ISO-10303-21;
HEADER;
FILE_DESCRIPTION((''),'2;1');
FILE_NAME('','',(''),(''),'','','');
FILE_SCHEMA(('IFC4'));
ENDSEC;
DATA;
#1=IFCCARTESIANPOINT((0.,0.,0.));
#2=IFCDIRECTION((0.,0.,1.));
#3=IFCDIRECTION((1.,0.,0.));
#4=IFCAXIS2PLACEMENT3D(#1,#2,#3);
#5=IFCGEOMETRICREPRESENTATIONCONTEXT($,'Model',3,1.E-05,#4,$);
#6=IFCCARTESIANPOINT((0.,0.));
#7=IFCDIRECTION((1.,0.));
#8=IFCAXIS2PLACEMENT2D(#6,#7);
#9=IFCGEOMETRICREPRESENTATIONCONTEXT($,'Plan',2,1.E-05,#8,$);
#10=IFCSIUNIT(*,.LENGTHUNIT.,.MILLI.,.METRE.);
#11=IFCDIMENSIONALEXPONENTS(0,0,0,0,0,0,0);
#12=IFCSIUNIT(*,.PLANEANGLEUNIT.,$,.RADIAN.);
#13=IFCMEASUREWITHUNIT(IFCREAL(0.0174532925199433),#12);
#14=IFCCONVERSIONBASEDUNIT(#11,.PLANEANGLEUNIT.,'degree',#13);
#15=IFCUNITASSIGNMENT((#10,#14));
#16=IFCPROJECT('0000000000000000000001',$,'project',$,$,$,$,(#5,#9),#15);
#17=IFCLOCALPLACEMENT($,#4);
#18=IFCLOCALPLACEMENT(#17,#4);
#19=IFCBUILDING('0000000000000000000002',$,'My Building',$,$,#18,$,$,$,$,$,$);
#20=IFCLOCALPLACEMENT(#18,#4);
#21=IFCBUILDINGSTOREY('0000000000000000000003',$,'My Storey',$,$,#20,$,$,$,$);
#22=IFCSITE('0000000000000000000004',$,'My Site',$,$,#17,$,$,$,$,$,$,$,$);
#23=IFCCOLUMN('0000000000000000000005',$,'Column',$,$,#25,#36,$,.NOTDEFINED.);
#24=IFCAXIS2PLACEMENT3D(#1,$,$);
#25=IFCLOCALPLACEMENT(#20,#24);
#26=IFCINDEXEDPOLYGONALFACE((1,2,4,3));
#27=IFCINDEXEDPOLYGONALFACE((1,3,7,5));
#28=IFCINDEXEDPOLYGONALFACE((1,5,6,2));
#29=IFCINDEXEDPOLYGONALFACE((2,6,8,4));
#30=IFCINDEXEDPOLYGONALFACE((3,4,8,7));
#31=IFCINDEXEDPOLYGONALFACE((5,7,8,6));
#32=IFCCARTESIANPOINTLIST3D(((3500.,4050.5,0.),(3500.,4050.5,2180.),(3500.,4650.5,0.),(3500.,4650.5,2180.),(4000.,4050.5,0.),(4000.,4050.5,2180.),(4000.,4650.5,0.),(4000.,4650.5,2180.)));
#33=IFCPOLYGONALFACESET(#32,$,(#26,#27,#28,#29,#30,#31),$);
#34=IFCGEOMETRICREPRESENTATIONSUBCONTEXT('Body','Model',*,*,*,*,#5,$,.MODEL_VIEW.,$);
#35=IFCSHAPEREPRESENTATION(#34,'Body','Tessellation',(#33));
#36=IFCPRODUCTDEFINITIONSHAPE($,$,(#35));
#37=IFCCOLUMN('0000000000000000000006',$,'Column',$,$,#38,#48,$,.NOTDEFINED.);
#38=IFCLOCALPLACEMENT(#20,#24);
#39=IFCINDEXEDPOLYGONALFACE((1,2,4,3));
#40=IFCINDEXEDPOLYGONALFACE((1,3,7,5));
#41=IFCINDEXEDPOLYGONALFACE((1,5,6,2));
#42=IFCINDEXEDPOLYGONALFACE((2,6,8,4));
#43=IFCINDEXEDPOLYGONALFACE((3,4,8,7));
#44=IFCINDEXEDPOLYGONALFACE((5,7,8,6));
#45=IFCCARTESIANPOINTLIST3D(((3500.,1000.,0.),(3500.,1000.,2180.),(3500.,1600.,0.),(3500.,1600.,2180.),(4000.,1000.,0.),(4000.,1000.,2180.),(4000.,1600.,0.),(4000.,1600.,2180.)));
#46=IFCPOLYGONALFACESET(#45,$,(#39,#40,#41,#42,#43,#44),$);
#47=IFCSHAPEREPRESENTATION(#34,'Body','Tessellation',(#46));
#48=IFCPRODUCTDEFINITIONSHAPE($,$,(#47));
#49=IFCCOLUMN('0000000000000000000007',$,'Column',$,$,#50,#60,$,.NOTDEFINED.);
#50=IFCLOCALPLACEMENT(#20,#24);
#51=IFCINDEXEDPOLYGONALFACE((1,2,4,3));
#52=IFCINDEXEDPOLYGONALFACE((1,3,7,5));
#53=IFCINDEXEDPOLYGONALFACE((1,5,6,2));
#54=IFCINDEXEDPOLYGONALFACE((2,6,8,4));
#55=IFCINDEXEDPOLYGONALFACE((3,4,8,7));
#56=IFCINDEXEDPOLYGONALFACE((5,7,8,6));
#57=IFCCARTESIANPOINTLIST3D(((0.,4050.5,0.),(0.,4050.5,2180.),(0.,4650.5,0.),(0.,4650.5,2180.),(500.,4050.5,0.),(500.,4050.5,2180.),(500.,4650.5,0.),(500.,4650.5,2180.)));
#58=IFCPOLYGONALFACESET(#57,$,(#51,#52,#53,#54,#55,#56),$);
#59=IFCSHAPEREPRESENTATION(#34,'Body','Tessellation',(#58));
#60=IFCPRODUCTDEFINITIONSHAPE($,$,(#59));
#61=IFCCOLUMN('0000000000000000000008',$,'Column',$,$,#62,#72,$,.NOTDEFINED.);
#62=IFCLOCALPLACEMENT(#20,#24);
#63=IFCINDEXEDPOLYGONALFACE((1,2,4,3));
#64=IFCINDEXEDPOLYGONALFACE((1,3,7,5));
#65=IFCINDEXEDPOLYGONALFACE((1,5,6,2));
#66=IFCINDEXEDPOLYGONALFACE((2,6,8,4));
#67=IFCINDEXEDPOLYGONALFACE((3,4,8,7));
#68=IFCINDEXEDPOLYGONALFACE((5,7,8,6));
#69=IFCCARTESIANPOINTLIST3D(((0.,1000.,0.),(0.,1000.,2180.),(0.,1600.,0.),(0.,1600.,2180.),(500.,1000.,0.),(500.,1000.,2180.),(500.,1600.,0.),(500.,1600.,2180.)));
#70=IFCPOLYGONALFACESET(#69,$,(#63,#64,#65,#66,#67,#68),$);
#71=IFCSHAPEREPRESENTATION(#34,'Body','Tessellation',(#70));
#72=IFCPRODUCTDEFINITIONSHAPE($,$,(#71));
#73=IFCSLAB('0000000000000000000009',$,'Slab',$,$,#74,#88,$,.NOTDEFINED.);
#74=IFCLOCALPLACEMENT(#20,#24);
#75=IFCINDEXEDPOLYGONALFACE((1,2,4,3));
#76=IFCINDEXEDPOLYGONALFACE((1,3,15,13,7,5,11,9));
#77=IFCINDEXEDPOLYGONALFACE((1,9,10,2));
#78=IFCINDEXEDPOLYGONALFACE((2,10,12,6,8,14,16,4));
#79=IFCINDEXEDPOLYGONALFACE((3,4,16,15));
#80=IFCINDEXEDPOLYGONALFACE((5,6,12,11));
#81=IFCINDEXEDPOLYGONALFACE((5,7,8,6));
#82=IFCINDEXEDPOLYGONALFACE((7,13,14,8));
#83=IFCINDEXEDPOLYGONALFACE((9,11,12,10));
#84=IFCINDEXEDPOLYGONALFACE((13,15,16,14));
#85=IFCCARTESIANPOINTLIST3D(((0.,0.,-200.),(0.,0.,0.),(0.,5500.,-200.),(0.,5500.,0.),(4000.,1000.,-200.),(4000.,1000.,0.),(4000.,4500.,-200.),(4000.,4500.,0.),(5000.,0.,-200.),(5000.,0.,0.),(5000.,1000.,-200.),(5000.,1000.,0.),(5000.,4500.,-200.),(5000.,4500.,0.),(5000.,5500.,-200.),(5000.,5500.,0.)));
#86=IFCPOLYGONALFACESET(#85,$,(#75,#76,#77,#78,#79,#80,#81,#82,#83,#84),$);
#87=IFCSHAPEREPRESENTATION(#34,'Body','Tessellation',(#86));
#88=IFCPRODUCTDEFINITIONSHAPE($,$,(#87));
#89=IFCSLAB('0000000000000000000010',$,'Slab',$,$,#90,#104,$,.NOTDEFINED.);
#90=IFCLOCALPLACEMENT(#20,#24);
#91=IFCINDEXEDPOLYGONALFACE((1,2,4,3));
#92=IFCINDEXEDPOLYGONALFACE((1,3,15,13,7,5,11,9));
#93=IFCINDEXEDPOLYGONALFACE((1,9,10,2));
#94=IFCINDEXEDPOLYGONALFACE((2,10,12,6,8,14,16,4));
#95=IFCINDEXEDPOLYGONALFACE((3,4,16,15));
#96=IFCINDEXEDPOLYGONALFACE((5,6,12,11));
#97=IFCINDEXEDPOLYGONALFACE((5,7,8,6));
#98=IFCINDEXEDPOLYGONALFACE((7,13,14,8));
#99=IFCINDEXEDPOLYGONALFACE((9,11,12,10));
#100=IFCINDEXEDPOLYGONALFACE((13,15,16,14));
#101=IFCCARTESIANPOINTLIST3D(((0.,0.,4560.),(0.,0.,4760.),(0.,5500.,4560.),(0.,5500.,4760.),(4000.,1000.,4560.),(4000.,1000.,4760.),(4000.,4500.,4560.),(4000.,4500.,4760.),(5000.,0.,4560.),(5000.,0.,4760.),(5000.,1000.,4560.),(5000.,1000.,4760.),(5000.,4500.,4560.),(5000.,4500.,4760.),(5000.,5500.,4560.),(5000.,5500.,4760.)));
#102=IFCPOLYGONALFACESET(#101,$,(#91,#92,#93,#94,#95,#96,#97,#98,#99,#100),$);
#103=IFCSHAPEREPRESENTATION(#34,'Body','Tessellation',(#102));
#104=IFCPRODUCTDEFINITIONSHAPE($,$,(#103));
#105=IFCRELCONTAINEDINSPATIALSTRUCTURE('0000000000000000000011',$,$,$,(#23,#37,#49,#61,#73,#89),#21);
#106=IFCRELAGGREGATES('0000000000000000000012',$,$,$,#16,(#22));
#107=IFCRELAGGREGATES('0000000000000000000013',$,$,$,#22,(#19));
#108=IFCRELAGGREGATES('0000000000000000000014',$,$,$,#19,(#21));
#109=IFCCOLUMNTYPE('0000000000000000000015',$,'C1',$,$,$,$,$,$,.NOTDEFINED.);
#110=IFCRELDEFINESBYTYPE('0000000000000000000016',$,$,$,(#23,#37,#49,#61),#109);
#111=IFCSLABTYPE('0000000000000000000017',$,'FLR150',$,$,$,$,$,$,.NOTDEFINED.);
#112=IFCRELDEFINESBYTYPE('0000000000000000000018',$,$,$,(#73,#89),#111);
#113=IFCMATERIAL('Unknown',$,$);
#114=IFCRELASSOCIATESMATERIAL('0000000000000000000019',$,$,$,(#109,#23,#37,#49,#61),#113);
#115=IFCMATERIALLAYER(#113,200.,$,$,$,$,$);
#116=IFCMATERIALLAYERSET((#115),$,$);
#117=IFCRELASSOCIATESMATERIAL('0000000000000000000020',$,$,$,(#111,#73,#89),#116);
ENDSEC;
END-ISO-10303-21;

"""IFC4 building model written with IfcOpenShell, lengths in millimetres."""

from ifc_helpers import new_model, entity, si_unit, converted_unit, frame, origin_with_axes, origin_2d_with_axis, place, context, subcontext, project, spatial, line, indexed_curve, rectangle, outline, extrude, material, layer, layer_set, layer_usage, material_profile, profile_set, profile_usage, type_object, element, save


model = new_model("IFC4")

# Units and contexts
model_context = context("Model", 3, precision=1e-05, world=origin_with_axes())
plan_context = context("Plan", 2, precision=1e-05, world=origin_2d_with_axis())
body_context = subcontext(model_context, "Body", "Model", "MODEL_VIEW")
ifc_project = project(units=[si_unit("LENGTHUNIT", "METRE", prefix="MILLI"), converted_unit("PLANEANGLEUNIT", "degree", entity("IfcReal", 0.0174532925199433), si_unit("PLANEANGLEUNIT", "RADIAN"), dimensions=[0, 0, 0, 0, 0, 0, 0])], contexts=[model_context, plan_context])

# Site, building, storey
site_placement = place(None, origin_with_axes())
site = spatial("IfcSite", under=ifc_project, at=site_placement, Name="My Site")
building_placement = place(site_placement, origin_with_axes())
building = spatial("IfcBuilding", under=site, at=building_placement, Name="My Building")
storey_placement = place(building_placement, origin_with_axes())
storey = spatial("IfcBuildingStorey", under=building, at=storey_placement, Name="My Storey")

# Columns
ifc_material = material(Name="Unknown")
ifc_material_profile = material_profile(ifc_material, rectangle(XDim=500.0, YDim=600.0))
ifc_profile_set = profile_set([ifc_material_profile])
ifc_profile_usage_1 = profile_usage(ifc_profile_set, cardinal=5)
column_type = type_object("IfcColumnType", Name="C1", PredefinedType="NOTDEFINED", material=ifc_profile_set)
column_1_placement = place(storey_placement, frame((3750.0, 4350.5, 0.0), z_axis=(0.0, 0.0, 1.0), x_axis=(1.0, 0.0, 0.0)))
element("IfcColumn", 1, at=column_1_placement, inside=storey, type_object=column_type, material=ifc_profile_usage_1, Name="Column", PredefinedType="NOTDEFINED", context=body_context, shape_type="SweptSolid", body=[
    extrude(rectangle(XDim=500.0, YDim=600.0), origin_with_axes(), (0.0, 0.0, 1.0), 2180.0),
])
ifc_profile_usage_2 = profile_usage(ifc_profile_set, cardinal=5)
column_2_placement = place(storey_placement, frame((3750.0, 1300.0, 0.0), z_axis=(0.0, 0.0, 1.0), x_axis=(1.0, 0.0, 0.0)))
element("IfcColumn", 2, at=column_2_placement, inside=storey, type_object=column_type, material=ifc_profile_usage_2, Name="Column", PredefinedType="NOTDEFINED", context=body_context, shape_type="SweptSolid", body=[
    extrude(rectangle(XDim=500.0, YDim=600.0), origin_with_axes(), (0.0, 0.0, 1.0), 2180.0),
])
ifc_profile_usage_3 = profile_usage(ifc_profile_set, cardinal=5)
column_3_placement = place(storey_placement, frame((250.0, 4350.5, 0.0), z_axis=(0.0, 0.0, 1.0), x_axis=(1.0, 0.0, 0.0)))
element("IfcColumn", 3, at=column_3_placement, inside=storey, type_object=column_type, material=ifc_profile_usage_3, Name="Column", PredefinedType="NOTDEFINED", context=body_context, shape_type="SweptSolid", body=[
    extrude(rectangle(XDim=500.0, YDim=600.0), origin_with_axes(), (0.0, 0.0, 1.0), 2180.0),
])
ifc_profile_usage_4 = profile_usage(ifc_profile_set, cardinal=5)
column_4_placement = place(storey_placement, frame((250.0, 1300.0, 0.0), z_axis=(0.0, 0.0, 1.0), x_axis=(1.0, 0.0, 0.0)))
element("IfcColumn", 4, at=column_4_placement, inside=storey, type_object=column_type, material=ifc_profile_usage_4, Name="Column", PredefinedType="NOTDEFINED", context=body_context, shape_type="SweptSolid", body=[
    extrude(rectangle(XDim=500.0, YDim=600.0), origin_with_axes(), (0.0, 0.0, 1.0), 2180.0),
])

# Slabs
ifc_layer = layer(ifc_material, 200.0)
ifc_layer_set = layer_set([ifc_layer])
ifc_layer_usage_1 = layer_usage(ifc_layer_set, "AXIS3", "POSITIVE", 0.0)
slab_type = type_object("IfcSlabType", Name="FLR150", PredefinedType="NOTDEFINED", material=ifc_layer_set)
slab_1_placement = place(storey_placement, frame((0.0, 0.0, -200.0), z_axis=(0.0, 0.0, 1.0), x_axis=(1.0, 0.0, 0.0)))
element("IfcSlab", 5, at=slab_1_placement, inside=storey, type_object=slab_type, material=ifc_layer_usage_1, Name="Slab", PredefinedType="NOTDEFINED", context=body_context, shape_type="SweptSolid", body=[
    extrude(outline(indexed_curve([(0.0, 0.0), (5000.0, 0.0), (5000.0, 5500.0), (0.0, 5500.0), (5000.0, 4500.0), (5000.0, 1000.0), (4000.0, 4500.0), (4000.0, 1000.0)], segments=[line(6, 2), line(2, 1), line(1, 4), line(4, 3), line(3, 5), line(5, 7), line(7, 8), line(8, 6)], self_intersect=False)), None, (0.0, 0.0, 1.0), 200.0),
])
ifc_layer_usage_2 = layer_usage(ifc_layer_set, "AXIS3", "POSITIVE", 0.0)
slab_2_placement = place(storey_placement, frame((0.0, 0.0, 4560.0), z_axis=(0.0, 0.0, 1.0), x_axis=(1.0, 0.0, 0.0)))
element("IfcSlab", 6, at=slab_2_placement, inside=storey, type_object=slab_type, material=ifc_layer_usage_2, Name="Slab", PredefinedType="NOTDEFINED", context=body_context, shape_type="SweptSolid", body=[
    extrude(outline(indexed_curve([(0.0, 0.0), (5000.0, 0.0), (5000.0, 5500.0), (0.0, 5500.0), (5000.0, 4500.0), (5000.0, 1000.0), (4000.0, 4500.0), (4000.0, 1000.0)], segments=[line(6, 2), line(2, 1), line(1, 4), line(4, 3), line(3, 5), line(5, 7), line(7, 8), line(8, 6)], self_intersect=False)), None, (0.0, 0.0, 1.0), 200.0),
])

save(model, "model.ifc")
